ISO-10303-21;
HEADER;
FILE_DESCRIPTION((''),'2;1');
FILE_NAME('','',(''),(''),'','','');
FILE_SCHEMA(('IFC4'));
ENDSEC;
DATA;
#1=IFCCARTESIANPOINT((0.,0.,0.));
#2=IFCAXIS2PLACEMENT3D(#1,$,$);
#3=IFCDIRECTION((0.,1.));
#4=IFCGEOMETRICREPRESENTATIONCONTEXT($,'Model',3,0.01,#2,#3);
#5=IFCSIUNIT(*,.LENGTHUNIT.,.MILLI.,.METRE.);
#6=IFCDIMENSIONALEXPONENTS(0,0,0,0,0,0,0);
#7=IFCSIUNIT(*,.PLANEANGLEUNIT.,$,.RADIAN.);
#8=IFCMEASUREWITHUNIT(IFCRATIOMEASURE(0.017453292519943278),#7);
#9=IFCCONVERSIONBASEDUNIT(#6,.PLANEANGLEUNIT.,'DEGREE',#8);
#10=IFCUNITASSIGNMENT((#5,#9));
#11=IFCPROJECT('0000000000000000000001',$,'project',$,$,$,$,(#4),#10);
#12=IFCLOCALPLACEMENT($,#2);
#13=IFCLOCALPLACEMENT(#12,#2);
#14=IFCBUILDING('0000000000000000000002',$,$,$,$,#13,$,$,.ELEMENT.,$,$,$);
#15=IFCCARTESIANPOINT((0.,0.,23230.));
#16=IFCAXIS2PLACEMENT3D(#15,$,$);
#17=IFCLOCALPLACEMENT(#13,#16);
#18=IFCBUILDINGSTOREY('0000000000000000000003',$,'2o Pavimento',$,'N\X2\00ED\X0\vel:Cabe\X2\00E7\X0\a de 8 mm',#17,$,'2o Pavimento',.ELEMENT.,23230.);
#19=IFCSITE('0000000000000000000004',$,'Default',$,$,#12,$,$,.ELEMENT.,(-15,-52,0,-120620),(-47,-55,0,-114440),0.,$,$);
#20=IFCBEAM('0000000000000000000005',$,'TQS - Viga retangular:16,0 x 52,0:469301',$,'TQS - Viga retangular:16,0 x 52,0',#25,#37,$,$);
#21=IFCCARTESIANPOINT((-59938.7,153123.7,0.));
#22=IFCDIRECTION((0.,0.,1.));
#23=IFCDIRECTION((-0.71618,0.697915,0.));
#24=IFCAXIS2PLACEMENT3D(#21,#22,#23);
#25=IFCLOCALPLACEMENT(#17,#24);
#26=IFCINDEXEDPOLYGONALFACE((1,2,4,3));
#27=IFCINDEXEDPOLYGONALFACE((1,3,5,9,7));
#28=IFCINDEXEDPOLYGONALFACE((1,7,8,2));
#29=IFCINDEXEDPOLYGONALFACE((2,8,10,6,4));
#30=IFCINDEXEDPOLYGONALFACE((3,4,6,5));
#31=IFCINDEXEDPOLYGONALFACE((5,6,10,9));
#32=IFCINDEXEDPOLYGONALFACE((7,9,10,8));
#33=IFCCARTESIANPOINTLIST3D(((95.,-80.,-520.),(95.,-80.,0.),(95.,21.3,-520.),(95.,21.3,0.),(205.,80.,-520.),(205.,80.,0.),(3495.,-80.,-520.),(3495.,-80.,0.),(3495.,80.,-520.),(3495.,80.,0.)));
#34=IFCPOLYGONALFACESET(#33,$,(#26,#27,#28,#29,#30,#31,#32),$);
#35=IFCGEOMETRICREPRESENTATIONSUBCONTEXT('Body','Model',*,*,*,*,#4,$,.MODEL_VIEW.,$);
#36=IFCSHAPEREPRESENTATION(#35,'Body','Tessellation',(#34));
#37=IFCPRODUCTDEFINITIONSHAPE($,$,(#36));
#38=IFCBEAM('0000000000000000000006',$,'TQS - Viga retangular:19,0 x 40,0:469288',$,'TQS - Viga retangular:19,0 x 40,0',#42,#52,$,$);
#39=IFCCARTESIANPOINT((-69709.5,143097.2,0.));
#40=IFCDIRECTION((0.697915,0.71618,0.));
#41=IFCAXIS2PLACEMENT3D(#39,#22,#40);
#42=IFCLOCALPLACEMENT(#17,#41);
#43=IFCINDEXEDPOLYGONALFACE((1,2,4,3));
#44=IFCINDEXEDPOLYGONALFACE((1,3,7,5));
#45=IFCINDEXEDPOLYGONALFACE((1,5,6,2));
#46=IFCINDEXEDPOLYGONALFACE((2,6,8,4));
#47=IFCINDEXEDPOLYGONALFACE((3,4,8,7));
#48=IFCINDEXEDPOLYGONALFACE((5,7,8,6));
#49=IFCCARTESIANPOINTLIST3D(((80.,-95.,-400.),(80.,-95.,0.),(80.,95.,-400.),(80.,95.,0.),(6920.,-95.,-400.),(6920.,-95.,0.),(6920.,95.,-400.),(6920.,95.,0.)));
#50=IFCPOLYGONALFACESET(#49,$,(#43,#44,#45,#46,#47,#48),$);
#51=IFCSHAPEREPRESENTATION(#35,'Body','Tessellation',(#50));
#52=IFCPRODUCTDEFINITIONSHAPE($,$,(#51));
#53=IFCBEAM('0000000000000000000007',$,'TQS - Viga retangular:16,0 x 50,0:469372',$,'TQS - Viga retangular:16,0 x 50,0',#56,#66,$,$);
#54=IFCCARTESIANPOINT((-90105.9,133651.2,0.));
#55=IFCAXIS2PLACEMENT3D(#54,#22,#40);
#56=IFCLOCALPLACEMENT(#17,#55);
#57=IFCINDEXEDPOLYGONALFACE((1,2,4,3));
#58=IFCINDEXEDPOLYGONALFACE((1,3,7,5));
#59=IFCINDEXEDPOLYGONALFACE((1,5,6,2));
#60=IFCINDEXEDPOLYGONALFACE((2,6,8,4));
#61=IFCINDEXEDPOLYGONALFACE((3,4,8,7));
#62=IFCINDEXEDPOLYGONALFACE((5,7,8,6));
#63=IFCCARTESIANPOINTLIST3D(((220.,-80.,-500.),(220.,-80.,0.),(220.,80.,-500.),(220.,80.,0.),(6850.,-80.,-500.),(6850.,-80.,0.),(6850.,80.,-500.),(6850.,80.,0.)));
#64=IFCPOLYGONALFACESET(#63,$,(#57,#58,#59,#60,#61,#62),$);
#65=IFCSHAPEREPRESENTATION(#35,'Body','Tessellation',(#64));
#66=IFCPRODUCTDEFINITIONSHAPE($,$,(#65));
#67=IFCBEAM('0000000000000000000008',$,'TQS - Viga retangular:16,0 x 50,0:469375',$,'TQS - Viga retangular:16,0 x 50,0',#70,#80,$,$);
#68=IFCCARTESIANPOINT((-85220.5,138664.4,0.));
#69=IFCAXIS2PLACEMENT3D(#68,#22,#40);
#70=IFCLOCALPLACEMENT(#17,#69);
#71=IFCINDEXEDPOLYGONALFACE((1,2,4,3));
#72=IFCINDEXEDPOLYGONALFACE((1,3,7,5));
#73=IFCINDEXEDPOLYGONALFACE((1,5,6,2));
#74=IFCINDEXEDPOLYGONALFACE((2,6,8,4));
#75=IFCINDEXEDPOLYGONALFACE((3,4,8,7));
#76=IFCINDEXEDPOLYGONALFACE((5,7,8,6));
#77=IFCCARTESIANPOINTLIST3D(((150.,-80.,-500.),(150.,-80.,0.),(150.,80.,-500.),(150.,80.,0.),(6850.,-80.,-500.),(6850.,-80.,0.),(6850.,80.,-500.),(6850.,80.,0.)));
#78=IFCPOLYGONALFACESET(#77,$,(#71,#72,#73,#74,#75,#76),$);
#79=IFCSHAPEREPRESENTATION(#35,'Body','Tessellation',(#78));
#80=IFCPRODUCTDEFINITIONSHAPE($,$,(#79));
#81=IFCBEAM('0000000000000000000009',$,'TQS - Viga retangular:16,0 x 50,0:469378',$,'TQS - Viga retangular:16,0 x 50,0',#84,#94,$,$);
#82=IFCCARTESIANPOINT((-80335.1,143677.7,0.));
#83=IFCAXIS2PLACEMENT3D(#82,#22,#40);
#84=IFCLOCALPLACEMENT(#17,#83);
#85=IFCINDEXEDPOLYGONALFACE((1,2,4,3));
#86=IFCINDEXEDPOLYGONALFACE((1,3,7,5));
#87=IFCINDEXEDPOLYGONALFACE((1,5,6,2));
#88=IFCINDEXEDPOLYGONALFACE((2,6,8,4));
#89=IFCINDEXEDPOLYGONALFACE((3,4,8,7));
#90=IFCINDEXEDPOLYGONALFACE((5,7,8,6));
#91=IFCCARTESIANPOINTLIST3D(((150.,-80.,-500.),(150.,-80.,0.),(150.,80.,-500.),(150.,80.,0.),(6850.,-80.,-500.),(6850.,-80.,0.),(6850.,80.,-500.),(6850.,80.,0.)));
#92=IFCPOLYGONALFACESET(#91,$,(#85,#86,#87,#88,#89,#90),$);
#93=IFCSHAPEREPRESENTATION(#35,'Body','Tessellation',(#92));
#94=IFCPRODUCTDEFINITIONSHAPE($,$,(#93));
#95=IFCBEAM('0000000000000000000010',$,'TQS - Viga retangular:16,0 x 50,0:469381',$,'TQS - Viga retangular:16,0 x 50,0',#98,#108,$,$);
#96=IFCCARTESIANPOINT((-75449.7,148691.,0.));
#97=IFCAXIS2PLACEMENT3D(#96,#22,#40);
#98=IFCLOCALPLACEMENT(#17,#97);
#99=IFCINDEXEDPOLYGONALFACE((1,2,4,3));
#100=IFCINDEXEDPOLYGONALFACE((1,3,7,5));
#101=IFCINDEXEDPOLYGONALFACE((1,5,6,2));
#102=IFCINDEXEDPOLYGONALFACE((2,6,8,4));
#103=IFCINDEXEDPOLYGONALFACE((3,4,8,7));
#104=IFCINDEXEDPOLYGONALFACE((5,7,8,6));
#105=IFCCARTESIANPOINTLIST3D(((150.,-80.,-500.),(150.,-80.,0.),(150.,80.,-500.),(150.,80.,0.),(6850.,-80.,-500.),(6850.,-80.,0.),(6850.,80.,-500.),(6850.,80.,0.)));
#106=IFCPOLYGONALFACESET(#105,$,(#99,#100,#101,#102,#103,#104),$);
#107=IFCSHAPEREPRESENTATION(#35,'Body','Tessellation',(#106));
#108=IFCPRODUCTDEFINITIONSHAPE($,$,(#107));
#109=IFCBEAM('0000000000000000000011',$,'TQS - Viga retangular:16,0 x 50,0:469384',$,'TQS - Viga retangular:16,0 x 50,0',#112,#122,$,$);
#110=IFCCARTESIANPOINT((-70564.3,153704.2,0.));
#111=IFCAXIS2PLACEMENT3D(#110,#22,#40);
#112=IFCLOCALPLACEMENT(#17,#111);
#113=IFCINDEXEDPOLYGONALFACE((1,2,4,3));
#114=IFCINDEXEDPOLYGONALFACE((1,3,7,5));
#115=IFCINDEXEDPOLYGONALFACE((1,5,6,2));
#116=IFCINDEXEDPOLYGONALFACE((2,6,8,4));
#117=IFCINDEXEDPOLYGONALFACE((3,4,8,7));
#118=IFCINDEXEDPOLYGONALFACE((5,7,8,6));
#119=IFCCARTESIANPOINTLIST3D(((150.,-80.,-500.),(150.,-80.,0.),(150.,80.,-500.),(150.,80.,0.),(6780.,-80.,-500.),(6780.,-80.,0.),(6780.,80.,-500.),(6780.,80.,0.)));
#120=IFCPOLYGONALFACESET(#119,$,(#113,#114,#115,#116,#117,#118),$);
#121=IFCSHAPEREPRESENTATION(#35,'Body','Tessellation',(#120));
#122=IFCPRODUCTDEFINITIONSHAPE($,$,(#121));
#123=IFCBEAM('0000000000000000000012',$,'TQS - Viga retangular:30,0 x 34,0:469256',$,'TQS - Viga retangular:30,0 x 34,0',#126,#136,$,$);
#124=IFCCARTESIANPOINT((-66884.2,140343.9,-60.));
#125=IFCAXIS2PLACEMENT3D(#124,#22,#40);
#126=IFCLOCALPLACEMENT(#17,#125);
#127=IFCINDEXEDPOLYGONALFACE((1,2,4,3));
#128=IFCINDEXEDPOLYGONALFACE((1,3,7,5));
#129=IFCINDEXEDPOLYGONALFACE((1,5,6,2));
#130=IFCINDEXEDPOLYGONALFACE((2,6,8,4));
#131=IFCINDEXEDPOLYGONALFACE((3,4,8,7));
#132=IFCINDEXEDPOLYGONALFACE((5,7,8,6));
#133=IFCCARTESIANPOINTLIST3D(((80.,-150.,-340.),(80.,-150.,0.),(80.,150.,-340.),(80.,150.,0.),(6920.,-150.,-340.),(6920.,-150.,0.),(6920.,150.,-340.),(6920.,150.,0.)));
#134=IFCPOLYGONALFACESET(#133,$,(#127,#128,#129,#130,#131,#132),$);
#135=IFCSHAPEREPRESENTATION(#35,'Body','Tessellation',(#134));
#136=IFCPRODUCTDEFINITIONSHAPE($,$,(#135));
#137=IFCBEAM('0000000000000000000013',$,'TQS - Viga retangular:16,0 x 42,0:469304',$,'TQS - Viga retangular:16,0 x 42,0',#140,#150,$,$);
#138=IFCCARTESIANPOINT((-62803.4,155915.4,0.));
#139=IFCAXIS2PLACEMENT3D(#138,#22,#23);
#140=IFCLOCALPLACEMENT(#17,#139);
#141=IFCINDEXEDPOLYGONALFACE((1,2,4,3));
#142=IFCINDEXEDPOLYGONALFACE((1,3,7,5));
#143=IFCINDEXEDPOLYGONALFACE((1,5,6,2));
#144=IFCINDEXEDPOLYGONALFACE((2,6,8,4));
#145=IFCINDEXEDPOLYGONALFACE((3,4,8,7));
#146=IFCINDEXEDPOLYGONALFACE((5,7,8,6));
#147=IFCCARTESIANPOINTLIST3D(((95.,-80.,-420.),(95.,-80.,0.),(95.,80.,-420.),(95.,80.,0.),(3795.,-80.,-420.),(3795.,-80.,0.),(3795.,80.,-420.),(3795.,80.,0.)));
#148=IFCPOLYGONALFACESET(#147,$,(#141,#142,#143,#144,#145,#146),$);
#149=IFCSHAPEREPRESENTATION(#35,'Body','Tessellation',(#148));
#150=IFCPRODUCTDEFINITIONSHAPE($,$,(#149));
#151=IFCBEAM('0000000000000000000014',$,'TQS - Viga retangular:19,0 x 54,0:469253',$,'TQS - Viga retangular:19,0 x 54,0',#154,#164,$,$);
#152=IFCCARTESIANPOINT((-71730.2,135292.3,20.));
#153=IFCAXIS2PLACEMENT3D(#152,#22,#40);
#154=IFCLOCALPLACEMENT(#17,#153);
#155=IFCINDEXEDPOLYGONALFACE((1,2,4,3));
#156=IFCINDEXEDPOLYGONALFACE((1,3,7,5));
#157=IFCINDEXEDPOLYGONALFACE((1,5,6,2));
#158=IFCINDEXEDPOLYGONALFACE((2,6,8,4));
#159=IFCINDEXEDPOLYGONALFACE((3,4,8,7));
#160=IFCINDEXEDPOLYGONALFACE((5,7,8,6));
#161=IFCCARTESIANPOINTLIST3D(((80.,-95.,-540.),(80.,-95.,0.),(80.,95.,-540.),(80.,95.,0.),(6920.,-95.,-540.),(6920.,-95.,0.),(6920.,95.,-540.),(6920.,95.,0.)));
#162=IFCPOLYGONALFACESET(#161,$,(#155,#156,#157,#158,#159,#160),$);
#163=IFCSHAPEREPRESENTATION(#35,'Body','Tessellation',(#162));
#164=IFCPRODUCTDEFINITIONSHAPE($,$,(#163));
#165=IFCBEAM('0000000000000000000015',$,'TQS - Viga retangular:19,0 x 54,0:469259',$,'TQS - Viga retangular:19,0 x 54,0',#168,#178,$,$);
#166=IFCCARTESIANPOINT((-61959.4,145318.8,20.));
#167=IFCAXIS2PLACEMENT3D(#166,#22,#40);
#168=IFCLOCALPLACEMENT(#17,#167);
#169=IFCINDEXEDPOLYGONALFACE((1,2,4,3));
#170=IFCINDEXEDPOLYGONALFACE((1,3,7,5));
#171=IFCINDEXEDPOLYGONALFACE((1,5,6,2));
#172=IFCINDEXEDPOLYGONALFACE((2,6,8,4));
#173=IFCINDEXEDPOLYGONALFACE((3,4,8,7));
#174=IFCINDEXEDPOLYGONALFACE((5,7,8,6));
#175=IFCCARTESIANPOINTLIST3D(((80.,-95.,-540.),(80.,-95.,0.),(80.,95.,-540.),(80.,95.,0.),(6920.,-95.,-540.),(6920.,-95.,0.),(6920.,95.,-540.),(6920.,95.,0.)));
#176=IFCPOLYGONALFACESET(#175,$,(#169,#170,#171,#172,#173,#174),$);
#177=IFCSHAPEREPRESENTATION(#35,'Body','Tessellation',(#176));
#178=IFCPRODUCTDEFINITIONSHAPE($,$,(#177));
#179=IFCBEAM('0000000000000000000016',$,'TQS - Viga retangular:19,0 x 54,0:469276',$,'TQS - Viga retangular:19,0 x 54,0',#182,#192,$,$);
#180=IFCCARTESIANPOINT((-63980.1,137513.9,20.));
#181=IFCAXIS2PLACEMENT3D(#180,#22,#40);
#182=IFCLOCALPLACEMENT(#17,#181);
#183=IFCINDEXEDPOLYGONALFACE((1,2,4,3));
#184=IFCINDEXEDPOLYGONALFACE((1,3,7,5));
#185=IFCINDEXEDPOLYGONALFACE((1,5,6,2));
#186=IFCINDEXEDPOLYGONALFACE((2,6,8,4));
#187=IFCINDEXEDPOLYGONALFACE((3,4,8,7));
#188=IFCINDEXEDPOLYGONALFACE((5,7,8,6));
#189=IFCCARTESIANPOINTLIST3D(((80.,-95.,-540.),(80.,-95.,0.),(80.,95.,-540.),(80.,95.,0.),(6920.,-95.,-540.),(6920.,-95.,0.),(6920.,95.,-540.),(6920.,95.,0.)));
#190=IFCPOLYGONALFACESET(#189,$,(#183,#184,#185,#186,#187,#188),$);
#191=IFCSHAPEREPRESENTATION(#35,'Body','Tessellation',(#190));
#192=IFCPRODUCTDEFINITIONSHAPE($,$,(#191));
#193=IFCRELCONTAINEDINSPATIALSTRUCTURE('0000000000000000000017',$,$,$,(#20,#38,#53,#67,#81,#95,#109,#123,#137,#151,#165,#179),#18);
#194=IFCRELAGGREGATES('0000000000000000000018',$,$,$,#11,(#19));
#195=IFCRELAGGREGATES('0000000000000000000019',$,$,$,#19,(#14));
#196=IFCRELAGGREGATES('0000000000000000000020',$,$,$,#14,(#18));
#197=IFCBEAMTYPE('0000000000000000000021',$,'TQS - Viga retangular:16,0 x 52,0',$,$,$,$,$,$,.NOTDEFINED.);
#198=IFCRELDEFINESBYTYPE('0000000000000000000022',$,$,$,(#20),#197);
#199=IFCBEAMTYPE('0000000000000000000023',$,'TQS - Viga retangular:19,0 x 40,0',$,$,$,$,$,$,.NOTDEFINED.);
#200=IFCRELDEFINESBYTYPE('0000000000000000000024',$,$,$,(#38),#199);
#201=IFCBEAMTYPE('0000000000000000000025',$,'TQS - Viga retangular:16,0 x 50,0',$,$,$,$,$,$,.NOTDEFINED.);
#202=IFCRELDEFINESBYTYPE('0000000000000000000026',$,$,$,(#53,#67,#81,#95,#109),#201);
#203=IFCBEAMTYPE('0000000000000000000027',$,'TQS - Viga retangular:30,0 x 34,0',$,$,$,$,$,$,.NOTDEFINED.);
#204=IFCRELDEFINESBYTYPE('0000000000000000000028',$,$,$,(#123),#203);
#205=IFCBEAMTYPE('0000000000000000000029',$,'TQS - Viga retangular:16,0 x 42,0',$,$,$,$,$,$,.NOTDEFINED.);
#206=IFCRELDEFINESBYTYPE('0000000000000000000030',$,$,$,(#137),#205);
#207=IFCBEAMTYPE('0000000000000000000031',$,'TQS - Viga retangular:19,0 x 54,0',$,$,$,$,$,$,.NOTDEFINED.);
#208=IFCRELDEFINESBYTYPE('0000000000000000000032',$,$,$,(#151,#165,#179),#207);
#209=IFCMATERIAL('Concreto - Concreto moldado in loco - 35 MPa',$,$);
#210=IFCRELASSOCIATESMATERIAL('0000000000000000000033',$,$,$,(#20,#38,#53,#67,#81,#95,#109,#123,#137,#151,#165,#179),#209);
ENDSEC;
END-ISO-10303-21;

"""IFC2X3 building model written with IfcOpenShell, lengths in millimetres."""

from ifc_helpers import new_model, entity, si_unit, converted_unit, direction, frame, frame_2d, origin, origin_2d_with_axis, place, context, subcontext, project, spatial, rectangle, extrude, clip, halfspace, material, type_object, element, save


model = new_model("IFC2X3")

# Units and contexts
model_context = context("Model", 3, precision=0.01, world=origin(), true_north=direction((0.0, 1.0)))
body_context = subcontext(model_context, "Body", "Model", "MODEL_VIEW")
ifc_project = project(units=[si_unit("LENGTHUNIT", "METRE", prefix="MILLI"), converted_unit("PLANEANGLEUNIT", "DEGREE", entity("IfcRatioMeasure", 0.017453292519943278), si_unit("PLANEANGLEUNIT", "RADIAN"), dimensions=[0, 0, 0, 0, 0, 0, 0])], contexts=[model_context])

# Site, building, storey
site_placement = place(None, origin())
site = spatial("IfcSite", under=ifc_project, at=site_placement, Name="Default", CompositionType="ELEMENT", RefLatitude=(-15, -52, 0, -120620), RefLongitude=(-47, -55, 0, -114440), RefElevation=0.0)
building_placement = place(site_placement, origin())
building = spatial("IfcBuilding", under=site, at=building_placement, CompositionType="ELEMENT")
storey_placement = place(building_placement, frame((0.0, 0.0, 23230.0)))
storey = spatial("IfcBuildingStorey", under=building, at=storey_placement, Name="2o Pavimento", ObjectType="Nível:Cabeça de 8 mm", LongName="2o Pavimento", CompositionType="ELEMENT", Elevation=23230.0)

# Beams
ifc_material = material(Name="Concreto - Concreto moldado in loco - 35 MPa")
beam_type_1 = type_object("IfcBeamType", Name="TQS - Viga retangular:16,0 x 52,0", PredefinedType="NOTDEFINED")
beam_1_placement = place(storey_placement, frame((-59938.7, 153123.7, 0.0), z_axis=(0.0, 0.0, 1.0), x_axis=(-0.71618, 0.697915, 0.0)))
element("IfcBeam", 1, at=beam_1_placement, inside=storey, type_object=beam_type_1, material=ifc_material, Name="TQS - Viga retangular:16,0 x 52,0:469301", ObjectType="TQS - Viga retangular:16,0 x 52,0", context=body_context, shape_type="SweptSolid", body=[
    clip(extrude(rectangle(XDim=520.0, YDim=160.0, at=frame_2d((0.0, 0.0), x_axis=(1.0, 0.0))), frame((95.0, 0.0, -260.0), z_axis=(1.0, 0.0, 0.0), x_axis=(0.0, 0.0, -1.0)), (0.0, 0.0, 1.0), 3400.0), halfspace(frame((205.0, 80.0, 0.0), z_axis=(-0.470588, 0.882353, 0.0), x_axis=(-0.882353, -0.470588, 0.0)), False)),
])
beam_type_2 = type_object("IfcBeamType", Name="TQS - Viga retangular:19,0 x 40,0", PredefinedType="NOTDEFINED")
beam_2_placement = place(storey_placement, frame((-69709.5, 143097.2, 0.0), z_axis=(0.0, 0.0, 1.0), x_axis=(0.697915, 0.71618, 0.0)))
element("IfcBeam", 2, at=beam_2_placement, inside=storey, type_object=beam_type_2, material=ifc_material, Name="TQS - Viga retangular:19,0 x 40,0:469288", ObjectType="TQS - Viga retangular:19,0 x 40,0", context=body_context, shape_type="SweptSolid", body=[
    extrude(rectangle(XDim=400.0, YDim=190.0, at=frame_2d((0.0, 0.0), x_axis=(1.0, 0.0))), frame((80.0, 0.0, -200.0), z_axis=(1.0, 0.0, 0.0), x_axis=(0.0, 0.0, -1.0)), (0.0, 0.0, 1.0), 6840.0),
])
beam_type_3 = type_object("IfcBeamType", Name="TQS - Viga retangular:16,0 x 50,0", PredefinedType="NOTDEFINED")
beam_3_placement = place(storey_placement, frame((-90105.9, 133651.2, 0.0), z_axis=(0.0, 0.0, 1.0), x_axis=(0.697915, 0.71618, 0.0)))
element("IfcBeam", 3, at=beam_3_placement, inside=storey, type_object=beam_type_3, material=ifc_material, Name="TQS - Viga retangular:16,0 x 50,0:469372", ObjectType="TQS - Viga retangular:16,0 x 50,0", context=body_context, shape_type="SweptSolid", body=[
    extrude(rectangle(XDim=500.0, YDim=160.0, at=frame_2d((0.0, 0.0), x_axis=(1.0, 0.0))), frame((220.0, 0.0, -250.0), z_axis=(1.0, 0.0, 0.0), x_axis=(0.0, 0.0, -1.0)), (0.0, 0.0, 1.0), 6630.0),
])
beam_4_placement = place(storey_placement, frame((-85220.5, 138664.4, 0.0), z_axis=(0.0, 0.0, 1.0), x_axis=(0.697915, 0.71618, 0.0)))
element("IfcBeam", 4, at=beam_4_placement, inside=storey, type_object=beam_type_3, material=ifc_material, Name="TQS - Viga retangular:16,0 x 50,0:469375", ObjectType="TQS - Viga retangular:16,0 x 50,0", context=body_context, shape_type="SweptSolid", body=[
    extrude(rectangle(XDim=500.0, YDim=160.0, at=origin_2d_with_axis()), frame((150.0, 0.0, -250.0), z_axis=(1.0, 0.0, 0.0), x_axis=(0.0, 0.0, -1.0)), (0.0, 0.0, 1.0), 6700.0),
])
beam_5_placement = place(storey_placement, frame((-80335.1, 143677.7, 0.0), z_axis=(0.0, 0.0, 1.0), x_axis=(0.697915, 0.71618, 0.0)))
element("IfcBeam", 5, at=beam_5_placement, inside=storey, type_object=beam_type_3, material=ifc_material, Name="TQS - Viga retangular:16,0 x 50,0:469378", ObjectType="TQS - Viga retangular:16,0 x 50,0", context=body_context, shape_type="SweptSolid", body=[
    extrude(rectangle(XDim=500.0, YDim=160.0, at=frame_2d((0.0, 0.0), x_axis=(1.0, 0.0))), frame((150.0, 0.0, -250.0), z_axis=(1.0, 0.0, 0.0), x_axis=(0.0, 0.0, -1.0)), (0.0, 0.0, 1.0), 6700.0),
])
beam_6_placement = place(storey_placement, frame((-75449.7, 148691.0, 0.0), z_axis=(0.0, 0.0, 1.0), x_axis=(0.697915, 0.71618, 0.0)))
element("IfcBeam", 6, at=beam_6_placement, inside=storey, type_object=beam_type_3, material=ifc_material, Name="TQS - Viga retangular:16,0 x 50,0:469381", ObjectType="TQS - Viga retangular:16,0 x 50,0", context=body_context, shape_type="SweptSolid", body=[
    extrude(rectangle(XDim=500.0, YDim=160.0, at=origin_2d_with_axis()), frame((150.0, 0.0, -250.0), z_axis=(1.0, 0.0, 0.0), x_axis=(0.0, 0.0, -1.0)), (0.0, 0.0, 1.0), 6700.0),
])
beam_7_placement = place(storey_placement, frame((-70564.3, 153704.2, 0.0), z_axis=(0.0, 0.0, 1.0), x_axis=(0.697915, 0.71618, 0.0)))
element("IfcBeam", 7, at=beam_7_placement, inside=storey, type_object=beam_type_3, material=ifc_material, Name="TQS - Viga retangular:16,0 x 50,0:469384", ObjectType="TQS - Viga retangular:16,0 x 50,0", context=body_context, shape_type="SweptSolid", body=[
    extrude(rectangle(XDim=500.0, YDim=160.0, at=frame_2d((0.0, 0.0), x_axis=(1.0, 0.0))), frame((150.0, 0.0, -250.0), z_axis=(1.0, 0.0, 0.0), x_axis=(0.0, 0.0, -1.0)), (0.0, 0.0, 1.0), 6630.0),
])
beam_type_4 = type_object("IfcBeamType", Name="TQS - Viga retangular:30,0 x 34,0", PredefinedType="NOTDEFINED")
beam_8_placement = place(storey_placement, frame((-66884.2, 140343.9, -60.0), z_axis=(0.0, 0.0, 1.0), x_axis=(0.697915, 0.71618, 0.0)))
element("IfcBeam", 8, at=beam_8_placement, inside=storey, type_object=beam_type_4, material=ifc_material, Name="TQS - Viga retangular:30,0 x 34,0:469256", ObjectType="TQS - Viga retangular:30,0 x 34,0", context=body_context, shape_type="SweptSolid", body=[
    extrude(rectangle(XDim=340.0, YDim=300.0, at=frame_2d((0.0, 0.0), x_axis=(1.0, 0.0))), frame((80.0, 0.0, -170.0), z_axis=(1.0, 0.0, 0.0), x_axis=(0.0, 0.0, -1.0)), (0.0, 0.0, 1.0), 6840.0),
])
beam_type_5 = type_object("IfcBeamType", Name="TQS - Viga retangular:16,0 x 42,0", PredefinedType="NOTDEFINED")
beam_9_placement = place(storey_placement, frame((-62803.4, 155915.4, 0.0), z_axis=(0.0, 0.0, 1.0), x_axis=(-0.71618, 0.697915, 0.0)))
element("IfcBeam", 9, at=beam_9_placement, inside=storey, type_object=beam_type_5, material=ifc_material, Name="TQS - Viga retangular:16,0 x 42,0:469304", ObjectType="TQS - Viga retangular:16,0 x 42,0", context=body_context, shape_type="SweptSolid", body=[
    extrude(rectangle(XDim=420.0, YDim=160.0, at=frame_2d((0.0, 0.0), x_axis=(1.0, 0.0))), frame((95.0, 0.0, -210.0), z_axis=(1.0, 0.0, 0.0), x_axis=(0.0, 0.0, -1.0)), (0.0, 0.0, 1.0), 3700.0),
])
beam_type_6 = type_object("IfcBeamType", Name="TQS - Viga retangular:19,0 x 54,0", PredefinedType="NOTDEFINED")
beam_10_placement = place(storey_placement, frame((-71730.2, 135292.3, 20.0), z_axis=(0.0, 0.0, 1.0), x_axis=(0.697915, 0.71618, 0.0)))
element("IfcBeam", 10, at=beam_10_placement, inside=storey, type_object=beam_type_6, material=ifc_material, Name="TQS - Viga retangular:19,0 x 54,0:469253", ObjectType="TQS - Viga retangular:19,0 x 54,0", context=body_context, shape_type="SweptSolid", body=[
    extrude(rectangle(XDim=540.0, YDim=190.0, at=frame_2d((0.0, 0.0), x_axis=(1.0, 0.0))), frame((80.0, 0.0, -270.0), z_axis=(1.0, 0.0, 0.0), x_axis=(0.0, 0.0, -1.0)), (0.0, 0.0, 1.0), 6840.0),
])
beam_11_placement = place(storey_placement, frame((-61959.4, 145318.8, 20.0), z_axis=(0.0, 0.0, 1.0), x_axis=(0.697915, 0.71618, 0.0)))
element("IfcBeam", 11, at=beam_11_placement, inside=storey, type_object=beam_type_6, material=ifc_material, Name="TQS - Viga retangular:19,0 x 54,0:469259", ObjectType="TQS - Viga retangular:19,0 x 54,0", context=body_context, shape_type="SweptSolid", body=[
    extrude(rectangle(XDim=540.0, YDim=190.0, at=frame_2d((0.0, 0.0), x_axis=(1.0, 0.0))), frame((80.0, 0.0, -270.0), z_axis=(1.0, 0.0, 0.0), x_axis=(0.0, 0.0, -1.0)), (0.0, 0.0, 1.0), 6840.0),
])
beam_12_placement = place(storey_placement, frame((-63980.1, 137513.9, 20.0), z_axis=(0.0, 0.0, 1.0), x_axis=(0.697915, 0.71618, 0.0)))
element("IfcBeam", 12, at=beam_12_placement, inside=storey, type_object=beam_type_6, material=ifc_material, Name="TQS - Viga retangular:19,0 x 54,0:469276", ObjectType="TQS - Viga retangular:19,0 x 54,0", context=body_context, shape_type="SweptSolid", body=[
    extrude(rectangle(XDim=540.0, YDim=190.0, at=frame_2d((0.0, 0.0), x_axis=(1.0, 0.0))), frame((80.0, 0.0, -270.0), z_axis=(1.0, 0.0, 0.0), x_axis=(0.0, 0.0, -1.0)), (0.0, 0.0, 1.0), 6840.0),
])

save(model, "model.ifc")
